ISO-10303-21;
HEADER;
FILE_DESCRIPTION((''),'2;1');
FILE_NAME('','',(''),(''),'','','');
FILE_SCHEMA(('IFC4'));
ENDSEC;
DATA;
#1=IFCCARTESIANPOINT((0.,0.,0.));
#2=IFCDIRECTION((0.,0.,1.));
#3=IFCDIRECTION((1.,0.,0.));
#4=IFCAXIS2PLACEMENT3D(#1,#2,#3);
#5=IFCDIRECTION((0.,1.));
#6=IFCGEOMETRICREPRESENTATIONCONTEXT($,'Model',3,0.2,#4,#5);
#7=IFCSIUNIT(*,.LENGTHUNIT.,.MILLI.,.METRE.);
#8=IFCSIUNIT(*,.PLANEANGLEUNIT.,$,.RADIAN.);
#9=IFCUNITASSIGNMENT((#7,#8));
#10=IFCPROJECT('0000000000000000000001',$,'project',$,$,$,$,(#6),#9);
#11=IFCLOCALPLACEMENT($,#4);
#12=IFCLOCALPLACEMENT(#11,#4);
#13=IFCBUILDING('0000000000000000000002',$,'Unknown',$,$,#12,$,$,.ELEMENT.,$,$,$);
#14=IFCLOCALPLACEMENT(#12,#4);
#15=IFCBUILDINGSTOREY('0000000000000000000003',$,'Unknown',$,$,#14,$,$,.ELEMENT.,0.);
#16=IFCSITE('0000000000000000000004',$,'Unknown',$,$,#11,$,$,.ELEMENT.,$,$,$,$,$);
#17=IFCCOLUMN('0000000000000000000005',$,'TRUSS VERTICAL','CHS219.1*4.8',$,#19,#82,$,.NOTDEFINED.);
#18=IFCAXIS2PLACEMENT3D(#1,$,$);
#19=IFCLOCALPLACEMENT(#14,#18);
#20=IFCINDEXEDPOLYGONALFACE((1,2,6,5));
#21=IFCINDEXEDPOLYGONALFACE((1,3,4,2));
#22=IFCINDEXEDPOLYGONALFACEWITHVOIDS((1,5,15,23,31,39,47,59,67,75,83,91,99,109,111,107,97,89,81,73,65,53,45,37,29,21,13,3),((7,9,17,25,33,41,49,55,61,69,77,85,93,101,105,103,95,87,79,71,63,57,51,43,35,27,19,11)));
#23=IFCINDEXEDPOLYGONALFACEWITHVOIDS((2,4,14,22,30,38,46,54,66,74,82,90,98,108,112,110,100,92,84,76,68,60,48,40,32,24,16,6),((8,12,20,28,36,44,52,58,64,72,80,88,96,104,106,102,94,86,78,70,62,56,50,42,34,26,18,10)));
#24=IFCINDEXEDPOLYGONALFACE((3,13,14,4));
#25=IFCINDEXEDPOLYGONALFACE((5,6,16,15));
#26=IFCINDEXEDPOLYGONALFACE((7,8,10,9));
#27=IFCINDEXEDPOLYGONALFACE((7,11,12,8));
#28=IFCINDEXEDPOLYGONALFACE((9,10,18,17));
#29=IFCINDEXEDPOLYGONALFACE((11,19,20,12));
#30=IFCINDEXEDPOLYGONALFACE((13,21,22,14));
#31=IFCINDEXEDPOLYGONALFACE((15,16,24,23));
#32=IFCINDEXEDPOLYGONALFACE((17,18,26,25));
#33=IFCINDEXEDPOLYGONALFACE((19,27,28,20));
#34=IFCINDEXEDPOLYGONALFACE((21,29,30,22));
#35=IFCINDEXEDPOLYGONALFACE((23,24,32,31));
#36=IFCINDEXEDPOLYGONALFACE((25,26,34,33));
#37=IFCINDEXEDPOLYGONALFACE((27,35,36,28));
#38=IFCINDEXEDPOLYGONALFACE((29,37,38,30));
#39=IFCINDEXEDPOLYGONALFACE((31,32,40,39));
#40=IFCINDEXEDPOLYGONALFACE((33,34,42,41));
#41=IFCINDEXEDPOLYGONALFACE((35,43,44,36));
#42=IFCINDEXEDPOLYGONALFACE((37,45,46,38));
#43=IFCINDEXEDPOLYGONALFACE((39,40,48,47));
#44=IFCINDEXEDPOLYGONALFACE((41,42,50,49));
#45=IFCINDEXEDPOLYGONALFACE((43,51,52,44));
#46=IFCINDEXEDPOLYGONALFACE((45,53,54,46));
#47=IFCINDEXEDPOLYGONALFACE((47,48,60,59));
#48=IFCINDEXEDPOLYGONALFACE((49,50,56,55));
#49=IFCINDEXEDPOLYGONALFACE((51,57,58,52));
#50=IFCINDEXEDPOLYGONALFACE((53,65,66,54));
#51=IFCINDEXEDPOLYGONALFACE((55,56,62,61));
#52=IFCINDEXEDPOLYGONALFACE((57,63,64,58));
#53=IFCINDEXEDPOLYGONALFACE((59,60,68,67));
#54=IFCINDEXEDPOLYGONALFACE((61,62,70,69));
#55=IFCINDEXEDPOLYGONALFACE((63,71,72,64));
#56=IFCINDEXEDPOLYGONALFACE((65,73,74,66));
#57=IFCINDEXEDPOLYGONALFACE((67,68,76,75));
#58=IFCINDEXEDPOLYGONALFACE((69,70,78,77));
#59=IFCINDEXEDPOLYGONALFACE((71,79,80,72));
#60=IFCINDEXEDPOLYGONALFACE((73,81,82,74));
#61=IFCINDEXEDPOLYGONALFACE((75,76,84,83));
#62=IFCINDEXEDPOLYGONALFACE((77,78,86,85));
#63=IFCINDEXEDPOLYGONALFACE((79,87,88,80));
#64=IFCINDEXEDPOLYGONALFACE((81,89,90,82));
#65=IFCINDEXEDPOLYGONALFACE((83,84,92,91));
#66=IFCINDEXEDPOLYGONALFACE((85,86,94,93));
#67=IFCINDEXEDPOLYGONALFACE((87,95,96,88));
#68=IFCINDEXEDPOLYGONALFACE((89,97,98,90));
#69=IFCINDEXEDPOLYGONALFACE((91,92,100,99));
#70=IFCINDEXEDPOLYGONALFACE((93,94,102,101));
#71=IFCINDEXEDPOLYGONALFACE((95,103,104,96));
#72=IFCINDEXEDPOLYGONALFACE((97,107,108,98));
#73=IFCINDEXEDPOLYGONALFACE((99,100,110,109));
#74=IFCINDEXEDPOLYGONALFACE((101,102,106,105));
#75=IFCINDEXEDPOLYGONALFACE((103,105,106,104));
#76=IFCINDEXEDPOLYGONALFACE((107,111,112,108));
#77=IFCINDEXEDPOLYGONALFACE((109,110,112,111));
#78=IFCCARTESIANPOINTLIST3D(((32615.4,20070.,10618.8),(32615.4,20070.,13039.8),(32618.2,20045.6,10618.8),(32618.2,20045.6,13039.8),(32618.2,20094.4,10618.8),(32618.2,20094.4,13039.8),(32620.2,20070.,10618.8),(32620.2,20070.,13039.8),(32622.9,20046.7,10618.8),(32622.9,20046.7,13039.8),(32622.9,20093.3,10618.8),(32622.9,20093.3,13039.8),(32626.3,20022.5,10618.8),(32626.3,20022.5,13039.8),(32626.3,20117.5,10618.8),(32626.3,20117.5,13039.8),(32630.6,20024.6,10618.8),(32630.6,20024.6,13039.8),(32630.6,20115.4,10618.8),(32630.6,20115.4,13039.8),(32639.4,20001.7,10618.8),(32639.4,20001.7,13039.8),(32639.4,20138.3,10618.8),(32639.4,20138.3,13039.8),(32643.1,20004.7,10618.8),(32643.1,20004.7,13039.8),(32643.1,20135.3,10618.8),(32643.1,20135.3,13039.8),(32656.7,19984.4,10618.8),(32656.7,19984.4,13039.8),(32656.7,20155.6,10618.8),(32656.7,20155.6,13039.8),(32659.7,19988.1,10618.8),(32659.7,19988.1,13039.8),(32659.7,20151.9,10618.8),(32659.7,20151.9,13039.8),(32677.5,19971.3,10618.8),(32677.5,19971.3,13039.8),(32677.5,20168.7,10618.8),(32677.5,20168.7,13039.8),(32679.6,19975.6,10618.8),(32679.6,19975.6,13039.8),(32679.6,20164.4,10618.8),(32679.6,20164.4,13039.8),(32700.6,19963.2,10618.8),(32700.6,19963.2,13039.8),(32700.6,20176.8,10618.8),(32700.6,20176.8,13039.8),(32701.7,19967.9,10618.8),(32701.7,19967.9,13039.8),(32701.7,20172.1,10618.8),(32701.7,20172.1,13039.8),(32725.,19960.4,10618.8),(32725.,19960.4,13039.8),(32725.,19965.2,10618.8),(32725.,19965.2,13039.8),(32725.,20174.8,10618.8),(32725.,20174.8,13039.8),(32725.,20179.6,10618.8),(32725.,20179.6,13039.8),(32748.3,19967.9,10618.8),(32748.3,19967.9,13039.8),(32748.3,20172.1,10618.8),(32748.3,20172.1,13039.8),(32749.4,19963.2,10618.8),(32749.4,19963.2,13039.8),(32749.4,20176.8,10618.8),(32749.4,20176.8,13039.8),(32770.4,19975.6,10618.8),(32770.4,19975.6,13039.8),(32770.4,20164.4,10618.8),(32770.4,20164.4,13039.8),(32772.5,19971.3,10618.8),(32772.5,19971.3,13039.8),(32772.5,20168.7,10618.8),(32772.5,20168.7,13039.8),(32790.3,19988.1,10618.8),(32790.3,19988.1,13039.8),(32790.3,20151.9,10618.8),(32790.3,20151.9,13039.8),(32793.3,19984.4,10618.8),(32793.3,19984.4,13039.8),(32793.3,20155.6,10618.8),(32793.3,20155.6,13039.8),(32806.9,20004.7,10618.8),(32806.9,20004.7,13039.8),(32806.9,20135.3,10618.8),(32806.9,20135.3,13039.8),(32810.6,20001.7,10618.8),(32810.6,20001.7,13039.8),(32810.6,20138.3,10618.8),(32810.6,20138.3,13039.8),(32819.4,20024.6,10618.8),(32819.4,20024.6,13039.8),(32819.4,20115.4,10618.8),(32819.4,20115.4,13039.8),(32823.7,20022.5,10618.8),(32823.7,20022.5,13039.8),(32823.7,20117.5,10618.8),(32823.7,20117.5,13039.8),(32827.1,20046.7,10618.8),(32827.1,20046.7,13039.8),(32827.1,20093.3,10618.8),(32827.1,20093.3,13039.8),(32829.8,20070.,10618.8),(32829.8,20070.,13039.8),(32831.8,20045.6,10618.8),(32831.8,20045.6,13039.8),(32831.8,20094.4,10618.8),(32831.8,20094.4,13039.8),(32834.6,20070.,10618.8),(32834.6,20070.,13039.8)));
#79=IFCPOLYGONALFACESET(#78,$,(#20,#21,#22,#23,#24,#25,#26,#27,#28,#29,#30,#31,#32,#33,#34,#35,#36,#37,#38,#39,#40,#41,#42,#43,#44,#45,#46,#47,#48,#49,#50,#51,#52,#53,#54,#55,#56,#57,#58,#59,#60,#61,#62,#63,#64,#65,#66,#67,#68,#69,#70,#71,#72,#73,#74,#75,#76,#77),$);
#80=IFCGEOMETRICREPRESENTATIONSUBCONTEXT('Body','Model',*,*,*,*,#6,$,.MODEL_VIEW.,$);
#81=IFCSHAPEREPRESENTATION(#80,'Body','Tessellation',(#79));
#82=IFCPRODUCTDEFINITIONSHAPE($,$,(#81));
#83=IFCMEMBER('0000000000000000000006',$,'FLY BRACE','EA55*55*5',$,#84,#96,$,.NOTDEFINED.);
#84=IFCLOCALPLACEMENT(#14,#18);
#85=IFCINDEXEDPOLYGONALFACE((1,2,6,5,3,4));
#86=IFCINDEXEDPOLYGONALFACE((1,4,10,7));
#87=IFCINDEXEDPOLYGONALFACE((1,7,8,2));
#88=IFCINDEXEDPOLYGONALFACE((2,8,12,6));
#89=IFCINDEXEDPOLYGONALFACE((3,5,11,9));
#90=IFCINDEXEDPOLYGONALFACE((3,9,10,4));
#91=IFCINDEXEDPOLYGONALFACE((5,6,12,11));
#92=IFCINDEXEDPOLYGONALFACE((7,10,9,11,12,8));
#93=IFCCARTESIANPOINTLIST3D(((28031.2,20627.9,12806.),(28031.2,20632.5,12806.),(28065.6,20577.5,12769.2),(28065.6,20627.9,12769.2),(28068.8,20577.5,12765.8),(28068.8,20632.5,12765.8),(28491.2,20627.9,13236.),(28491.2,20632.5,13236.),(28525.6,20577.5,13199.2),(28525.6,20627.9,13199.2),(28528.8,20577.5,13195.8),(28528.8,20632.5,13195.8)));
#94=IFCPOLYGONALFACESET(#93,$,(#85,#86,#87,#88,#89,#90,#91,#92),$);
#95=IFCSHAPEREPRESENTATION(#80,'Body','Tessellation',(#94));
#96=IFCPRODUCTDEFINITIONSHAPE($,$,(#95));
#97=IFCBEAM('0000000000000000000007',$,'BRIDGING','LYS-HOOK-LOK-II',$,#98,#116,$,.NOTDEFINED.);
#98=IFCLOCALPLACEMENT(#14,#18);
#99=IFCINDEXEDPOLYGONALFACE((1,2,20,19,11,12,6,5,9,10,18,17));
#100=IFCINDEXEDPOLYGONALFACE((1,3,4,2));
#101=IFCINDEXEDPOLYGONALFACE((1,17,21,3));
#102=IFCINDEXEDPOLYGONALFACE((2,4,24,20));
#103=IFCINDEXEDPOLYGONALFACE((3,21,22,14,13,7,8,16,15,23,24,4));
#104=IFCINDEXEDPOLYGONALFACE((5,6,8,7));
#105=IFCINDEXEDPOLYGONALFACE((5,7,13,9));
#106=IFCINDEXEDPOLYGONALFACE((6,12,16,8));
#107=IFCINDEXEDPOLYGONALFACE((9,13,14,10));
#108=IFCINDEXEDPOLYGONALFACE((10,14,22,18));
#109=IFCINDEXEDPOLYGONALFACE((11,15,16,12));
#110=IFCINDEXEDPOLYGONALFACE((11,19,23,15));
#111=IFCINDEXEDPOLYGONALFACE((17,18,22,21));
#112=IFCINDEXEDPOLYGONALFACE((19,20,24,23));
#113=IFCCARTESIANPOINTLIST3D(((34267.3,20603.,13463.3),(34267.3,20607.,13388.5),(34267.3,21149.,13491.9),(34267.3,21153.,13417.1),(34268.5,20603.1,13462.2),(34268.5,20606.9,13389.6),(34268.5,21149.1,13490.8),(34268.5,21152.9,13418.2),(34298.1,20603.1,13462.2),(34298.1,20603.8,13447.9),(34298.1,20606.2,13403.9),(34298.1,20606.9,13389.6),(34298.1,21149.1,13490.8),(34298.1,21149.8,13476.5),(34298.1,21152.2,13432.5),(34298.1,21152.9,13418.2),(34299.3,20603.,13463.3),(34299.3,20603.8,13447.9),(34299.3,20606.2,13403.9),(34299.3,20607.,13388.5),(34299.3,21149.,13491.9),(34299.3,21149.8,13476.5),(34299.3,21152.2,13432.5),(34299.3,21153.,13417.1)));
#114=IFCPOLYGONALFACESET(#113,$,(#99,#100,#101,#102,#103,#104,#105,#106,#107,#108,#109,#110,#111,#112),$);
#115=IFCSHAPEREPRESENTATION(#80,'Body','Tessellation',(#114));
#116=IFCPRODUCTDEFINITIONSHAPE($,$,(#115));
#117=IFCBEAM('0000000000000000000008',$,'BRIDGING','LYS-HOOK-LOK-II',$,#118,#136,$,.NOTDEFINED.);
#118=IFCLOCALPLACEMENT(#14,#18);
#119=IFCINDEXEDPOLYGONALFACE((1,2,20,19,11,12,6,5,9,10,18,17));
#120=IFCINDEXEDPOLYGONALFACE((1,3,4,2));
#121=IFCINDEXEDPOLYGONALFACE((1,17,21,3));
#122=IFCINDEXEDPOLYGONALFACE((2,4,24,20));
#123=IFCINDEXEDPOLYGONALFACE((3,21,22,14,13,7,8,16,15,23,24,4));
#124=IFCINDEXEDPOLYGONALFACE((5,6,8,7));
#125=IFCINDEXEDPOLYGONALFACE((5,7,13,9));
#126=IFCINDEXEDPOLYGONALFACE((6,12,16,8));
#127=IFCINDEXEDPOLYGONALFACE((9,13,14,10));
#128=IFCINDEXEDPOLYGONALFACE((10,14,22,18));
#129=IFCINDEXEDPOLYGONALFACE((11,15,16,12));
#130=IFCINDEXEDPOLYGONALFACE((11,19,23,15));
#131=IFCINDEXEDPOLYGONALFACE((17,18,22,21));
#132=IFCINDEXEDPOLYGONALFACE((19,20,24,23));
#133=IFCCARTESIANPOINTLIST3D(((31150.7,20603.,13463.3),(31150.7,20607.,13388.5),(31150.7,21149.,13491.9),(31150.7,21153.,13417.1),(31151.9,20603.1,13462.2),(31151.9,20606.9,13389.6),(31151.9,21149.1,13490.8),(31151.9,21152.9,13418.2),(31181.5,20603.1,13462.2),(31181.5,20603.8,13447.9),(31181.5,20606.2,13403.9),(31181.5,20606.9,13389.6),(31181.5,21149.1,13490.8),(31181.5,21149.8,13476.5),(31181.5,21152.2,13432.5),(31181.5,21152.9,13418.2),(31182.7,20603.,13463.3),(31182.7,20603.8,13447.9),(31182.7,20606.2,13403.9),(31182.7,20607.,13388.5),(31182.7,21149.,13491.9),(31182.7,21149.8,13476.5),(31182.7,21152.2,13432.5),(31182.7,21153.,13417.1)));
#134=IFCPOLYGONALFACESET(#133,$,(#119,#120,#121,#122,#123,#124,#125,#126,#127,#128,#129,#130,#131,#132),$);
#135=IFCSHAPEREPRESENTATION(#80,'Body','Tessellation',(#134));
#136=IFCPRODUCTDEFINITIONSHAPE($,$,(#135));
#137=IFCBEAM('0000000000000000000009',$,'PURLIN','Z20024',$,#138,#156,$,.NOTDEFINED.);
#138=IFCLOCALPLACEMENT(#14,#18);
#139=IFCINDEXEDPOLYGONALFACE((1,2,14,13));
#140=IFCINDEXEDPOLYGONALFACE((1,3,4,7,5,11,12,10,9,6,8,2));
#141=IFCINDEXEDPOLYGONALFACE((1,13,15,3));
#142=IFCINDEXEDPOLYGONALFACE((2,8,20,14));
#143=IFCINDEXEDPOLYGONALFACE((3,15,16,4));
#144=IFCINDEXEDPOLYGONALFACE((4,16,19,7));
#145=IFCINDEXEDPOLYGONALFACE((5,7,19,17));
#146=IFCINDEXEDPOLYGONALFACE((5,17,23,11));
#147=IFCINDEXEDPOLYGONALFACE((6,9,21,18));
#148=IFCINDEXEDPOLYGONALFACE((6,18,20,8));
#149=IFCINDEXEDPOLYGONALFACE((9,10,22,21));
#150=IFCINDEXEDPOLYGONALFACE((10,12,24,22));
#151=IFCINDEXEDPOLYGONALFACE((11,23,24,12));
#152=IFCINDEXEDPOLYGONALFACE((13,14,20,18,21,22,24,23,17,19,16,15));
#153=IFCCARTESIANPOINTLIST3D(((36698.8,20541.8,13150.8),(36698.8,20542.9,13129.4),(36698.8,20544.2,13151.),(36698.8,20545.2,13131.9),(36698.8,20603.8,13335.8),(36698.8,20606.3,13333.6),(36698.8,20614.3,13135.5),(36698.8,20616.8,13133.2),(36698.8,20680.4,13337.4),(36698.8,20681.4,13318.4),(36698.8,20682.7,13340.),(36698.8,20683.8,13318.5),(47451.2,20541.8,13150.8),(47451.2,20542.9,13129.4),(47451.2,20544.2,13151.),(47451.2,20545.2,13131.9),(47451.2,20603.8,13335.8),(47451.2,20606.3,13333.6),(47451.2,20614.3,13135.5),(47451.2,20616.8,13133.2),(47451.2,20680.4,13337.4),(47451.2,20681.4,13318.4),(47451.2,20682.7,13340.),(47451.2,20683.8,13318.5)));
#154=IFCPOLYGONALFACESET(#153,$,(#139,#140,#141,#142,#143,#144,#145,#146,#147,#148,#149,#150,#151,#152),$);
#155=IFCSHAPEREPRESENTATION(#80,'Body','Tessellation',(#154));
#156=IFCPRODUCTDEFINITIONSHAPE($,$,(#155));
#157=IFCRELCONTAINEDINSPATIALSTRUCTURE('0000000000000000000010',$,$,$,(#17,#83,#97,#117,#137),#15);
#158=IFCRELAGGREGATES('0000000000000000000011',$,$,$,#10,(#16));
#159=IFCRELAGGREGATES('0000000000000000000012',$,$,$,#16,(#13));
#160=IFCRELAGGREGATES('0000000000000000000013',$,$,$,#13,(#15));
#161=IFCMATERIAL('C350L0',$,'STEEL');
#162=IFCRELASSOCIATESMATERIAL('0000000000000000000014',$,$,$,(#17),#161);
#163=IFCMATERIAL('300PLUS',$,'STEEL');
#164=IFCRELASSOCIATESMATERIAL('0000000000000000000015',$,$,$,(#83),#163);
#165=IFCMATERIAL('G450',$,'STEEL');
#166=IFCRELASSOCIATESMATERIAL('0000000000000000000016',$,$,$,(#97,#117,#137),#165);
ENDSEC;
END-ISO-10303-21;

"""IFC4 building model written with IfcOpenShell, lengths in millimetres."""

from ifc_helpers import new_model, si_unit, direction, frame, origin_with_axes, place, context, subcontext, project, spatial, line, indexed_curve, outline, extrude, material, element, save


model = new_model("IFC4")

# Units and contexts
model_context = context("Model", 3, precision=0.2, world=origin_with_axes(), true_north=direction((0.0, 1.0)))
body_context = subcontext(model_context, "Body", "Model", "MODEL_VIEW")
ifc_project = project(units=[si_unit("LENGTHUNIT", "METRE", prefix="MILLI"), si_unit("PLANEANGLEUNIT", "RADIAN")], contexts=[model_context])

# Site, building, storey
site_placement = place(None, origin_with_axes())
site = spatial("IfcSite", under=ifc_project, at=site_placement, Name="Unknown", CompositionType="ELEMENT")
building_placement = place(site_placement, origin_with_axes())
building = spatial("IfcBuilding", under=site, at=building_placement, Name="Unknown", CompositionType="ELEMENT")
storey_placement = place(building_placement, origin_with_axes())
storey = spatial("IfcBuildingStorey", under=building, at=storey_placement, Name="Unknown", CompositionType="ELEMENT", Elevation=0.0)

# Column
ifc_material_1 = material(Name="C350L0", Category="STEEL")
column_placement = place(storey_placement, frame((32725.0, 20070.0, 10618.8), z_axis=(-1.0, 0.0, 0.0), x_axis=(0.0, 0.0, 1.0)))
element("IfcColumn", 1, at=column_placement, inside=storey, material=ifc_material_1, Name="TRUSS VERTICAL", Description="CHS219.1*4.8", PredefinedType="NOTDEFINED", context=body_context, shape_type="SolidModel", body=[
    extrude(outline(indexed_curve([(109.5, 0.0), (106.8, 24.4), (98.7, 47.5), (85.6, 68.3), (68.3, 85.6), (47.5, 98.7), (24.4, 106.8), (0.0, 109.5), (-24.4, 106.8), (-47.5, 98.7), (-68.3, 85.6), (-85.6, 68.3), (-98.7, 47.5), (-106.8, 24.4), (-109.5, 0.0), (-106.8, -24.4), (-98.7, -47.5), (-85.6, -68.3), (-68.3, -85.6), (-47.5, -98.7), (-24.4, -106.8), (0.0, -109.5), (24.4, -106.8), (47.5, -98.7), (68.3, -85.6), (85.6, -68.3), (98.7, -47.5), (106.8, -24.4)], segments=[line(1, 2, 3, 4, 5, 6, 7, 8, 9, 10, 11, 12, 13, 14, 15, 16, 17, 18, 19, 20, 21, 22, 23, 24, 25, 26, 27, 28, 1)]), holes=[indexed_curve([(104.8, 0.0), (102.1, -23.3), (94.4, -45.4), (81.9, -65.3), (65.3, -81.9), (45.4, -94.4), (23.3, -102.1), (0.0, -104.8), (-23.3, -102.1), (-45.4, -94.4), (-65.3, -81.9), (-81.9, -65.3), (-94.4, -45.4), (-102.1, -23.3), (-104.8, 0.0), (-102.1, 23.3), (-94.4, 45.4), (-81.9, 65.3), (-65.3, 81.9), (-45.4, 94.4), (-23.3, 102.1), (0.0, 104.8), (23.3, 102.1), (45.4, 94.4), (65.3, 81.9), (81.9, 65.3), (94.4, 45.4), (102.1, 23.3)], segments=[line(1, 2, 3, 4, 5, 6, 7, 8, 9, 10, 11, 12, 13, 14, 15, 16, 17, 18, 19, 20, 21, 22, 23, 24, 25, 26, 27, 28, 1)])]), frame((0.0, 0.0, 0.0), z_axis=(-1.0, 0.0, 0.0), x_axis=(0.0, 0.0, 1.0)), (0.0, 0.0, -1.0), 2421.0),
])

# Member
ifc_material_2 = material(Name="300PLUS", Category="STEEL")
member_placement = place(storey_placement, frame((28510.0, 20605.0, 13215.9), z_axis=(-0.682884, 0.0, 0.730527), x_axis=(-0.730527, 0.0, -0.682884)))
element("IfcMember", 2, at=member_placement, inside=storey, material=ifc_material_2, Name="FLY BRACE", Description="EA55*55*5", PredefinedType="NOTDEFINED", context=body_context, shape_type="SolidModel", body=[
    extrude(outline(indexed_curve([(-27.5, -27.5), (27.5, -27.5), (27.5, -22.9), (-22.9, -22.9), (-22.9, 27.5), (-27.5, 27.5)], segments=[line(1, 2, 3, 4, 5, 6, 1)])), frame((0.0, 0.0, 0.0), z_axis=(-1.0, 0.0, 0.0), x_axis=(0.0, 0.0, 1.0)), (0.0, 0.0, -1.0), 629.7),
])

# Beams
ifc_material_3 = material(Name="G450", Category="STEEL")
for number, where, z_axis, x_axis, name in (
    (3, (34283.3, 20605.0, 13425.9), (1.0, 0.0, 0.0), (0.0, 0.998631, 0.052309), "BRIDGING"),
    (4, (31166.7, 20605.0, 13425.9), (1.0, 0.0, 0.0), (0.0, 0.998631, 0.052309), "BRIDGING"),
):
    element("IfcBeam", number, at=place(storey_placement, frame(where, z_axis=z_axis, x_axis=x_axis)), inside=storey, material=ifc_material_3, Name=name, Description="LYS-HOOK-LOK-II", PredefinedType="NOTDEFINED", context=body_context, shape_type="SolidModel", body=[
        extrude(outline(indexed_curve([(16.0, -37.5), (16.0, -22.0), (14.8, -22.0), (14.8, -36.3), (-14.8, -36.3), (-14.8, 36.3), (14.8, 36.3), (14.8, 22.0), (16.0, 22.0), (16.0, 37.5), (-16.0, 37.5), (-16.0, -37.5)], segments=[line(1, 2, 3, 4, 5, 6, 7, 8, 9, 10, 11, 12, 1)])), frame((0.0, 0.0, 0.0), z_axis=(-1.0, 0.0, 0.0), x_axis=(0.0, 0.0, 1.0)), (0.0, 0.0, -1.0), 546.7),
    ])
beam_1_placement = place(storey_placement, frame((36698.8, 20610.3, 13234.5), z_axis=(0.0, -0.99863, -0.052336), x_axis=(1.0, 0.0, 0.0)))
element("IfcBeam", 5, at=beam_1_placement, inside=storey, material=ifc_material_3, Name="PURLIN", Description="Z20024", PredefinedType="NOTDEFINED", context=body_context, shape_type="SolidModel", body=[
    extrude(outline(indexed_curve([(72.8, -101.5), (72.8, -80.0), (70.4, -80.0), (70.4, -99.1), (1.2, -99.1), (1.2, 101.5), (-77.8, 101.5), (-77.8, 80.0), (-75.4, 80.0), (-75.4, 99.1), (-1.2, 99.1), (-1.2, -101.5)], segments=[line(1, 2, 3, 4, 5, 6, 7, 8, 9, 10, 11, 12, 1)])), frame((0.0, 0.0, 0.0), z_axis=(-1.0, 0.0, 0.0), x_axis=(0.0, 0.0, 1.0)), (0.0, 0.0, -1.0), 10752.4),
])

save(model, "model.ifc")
